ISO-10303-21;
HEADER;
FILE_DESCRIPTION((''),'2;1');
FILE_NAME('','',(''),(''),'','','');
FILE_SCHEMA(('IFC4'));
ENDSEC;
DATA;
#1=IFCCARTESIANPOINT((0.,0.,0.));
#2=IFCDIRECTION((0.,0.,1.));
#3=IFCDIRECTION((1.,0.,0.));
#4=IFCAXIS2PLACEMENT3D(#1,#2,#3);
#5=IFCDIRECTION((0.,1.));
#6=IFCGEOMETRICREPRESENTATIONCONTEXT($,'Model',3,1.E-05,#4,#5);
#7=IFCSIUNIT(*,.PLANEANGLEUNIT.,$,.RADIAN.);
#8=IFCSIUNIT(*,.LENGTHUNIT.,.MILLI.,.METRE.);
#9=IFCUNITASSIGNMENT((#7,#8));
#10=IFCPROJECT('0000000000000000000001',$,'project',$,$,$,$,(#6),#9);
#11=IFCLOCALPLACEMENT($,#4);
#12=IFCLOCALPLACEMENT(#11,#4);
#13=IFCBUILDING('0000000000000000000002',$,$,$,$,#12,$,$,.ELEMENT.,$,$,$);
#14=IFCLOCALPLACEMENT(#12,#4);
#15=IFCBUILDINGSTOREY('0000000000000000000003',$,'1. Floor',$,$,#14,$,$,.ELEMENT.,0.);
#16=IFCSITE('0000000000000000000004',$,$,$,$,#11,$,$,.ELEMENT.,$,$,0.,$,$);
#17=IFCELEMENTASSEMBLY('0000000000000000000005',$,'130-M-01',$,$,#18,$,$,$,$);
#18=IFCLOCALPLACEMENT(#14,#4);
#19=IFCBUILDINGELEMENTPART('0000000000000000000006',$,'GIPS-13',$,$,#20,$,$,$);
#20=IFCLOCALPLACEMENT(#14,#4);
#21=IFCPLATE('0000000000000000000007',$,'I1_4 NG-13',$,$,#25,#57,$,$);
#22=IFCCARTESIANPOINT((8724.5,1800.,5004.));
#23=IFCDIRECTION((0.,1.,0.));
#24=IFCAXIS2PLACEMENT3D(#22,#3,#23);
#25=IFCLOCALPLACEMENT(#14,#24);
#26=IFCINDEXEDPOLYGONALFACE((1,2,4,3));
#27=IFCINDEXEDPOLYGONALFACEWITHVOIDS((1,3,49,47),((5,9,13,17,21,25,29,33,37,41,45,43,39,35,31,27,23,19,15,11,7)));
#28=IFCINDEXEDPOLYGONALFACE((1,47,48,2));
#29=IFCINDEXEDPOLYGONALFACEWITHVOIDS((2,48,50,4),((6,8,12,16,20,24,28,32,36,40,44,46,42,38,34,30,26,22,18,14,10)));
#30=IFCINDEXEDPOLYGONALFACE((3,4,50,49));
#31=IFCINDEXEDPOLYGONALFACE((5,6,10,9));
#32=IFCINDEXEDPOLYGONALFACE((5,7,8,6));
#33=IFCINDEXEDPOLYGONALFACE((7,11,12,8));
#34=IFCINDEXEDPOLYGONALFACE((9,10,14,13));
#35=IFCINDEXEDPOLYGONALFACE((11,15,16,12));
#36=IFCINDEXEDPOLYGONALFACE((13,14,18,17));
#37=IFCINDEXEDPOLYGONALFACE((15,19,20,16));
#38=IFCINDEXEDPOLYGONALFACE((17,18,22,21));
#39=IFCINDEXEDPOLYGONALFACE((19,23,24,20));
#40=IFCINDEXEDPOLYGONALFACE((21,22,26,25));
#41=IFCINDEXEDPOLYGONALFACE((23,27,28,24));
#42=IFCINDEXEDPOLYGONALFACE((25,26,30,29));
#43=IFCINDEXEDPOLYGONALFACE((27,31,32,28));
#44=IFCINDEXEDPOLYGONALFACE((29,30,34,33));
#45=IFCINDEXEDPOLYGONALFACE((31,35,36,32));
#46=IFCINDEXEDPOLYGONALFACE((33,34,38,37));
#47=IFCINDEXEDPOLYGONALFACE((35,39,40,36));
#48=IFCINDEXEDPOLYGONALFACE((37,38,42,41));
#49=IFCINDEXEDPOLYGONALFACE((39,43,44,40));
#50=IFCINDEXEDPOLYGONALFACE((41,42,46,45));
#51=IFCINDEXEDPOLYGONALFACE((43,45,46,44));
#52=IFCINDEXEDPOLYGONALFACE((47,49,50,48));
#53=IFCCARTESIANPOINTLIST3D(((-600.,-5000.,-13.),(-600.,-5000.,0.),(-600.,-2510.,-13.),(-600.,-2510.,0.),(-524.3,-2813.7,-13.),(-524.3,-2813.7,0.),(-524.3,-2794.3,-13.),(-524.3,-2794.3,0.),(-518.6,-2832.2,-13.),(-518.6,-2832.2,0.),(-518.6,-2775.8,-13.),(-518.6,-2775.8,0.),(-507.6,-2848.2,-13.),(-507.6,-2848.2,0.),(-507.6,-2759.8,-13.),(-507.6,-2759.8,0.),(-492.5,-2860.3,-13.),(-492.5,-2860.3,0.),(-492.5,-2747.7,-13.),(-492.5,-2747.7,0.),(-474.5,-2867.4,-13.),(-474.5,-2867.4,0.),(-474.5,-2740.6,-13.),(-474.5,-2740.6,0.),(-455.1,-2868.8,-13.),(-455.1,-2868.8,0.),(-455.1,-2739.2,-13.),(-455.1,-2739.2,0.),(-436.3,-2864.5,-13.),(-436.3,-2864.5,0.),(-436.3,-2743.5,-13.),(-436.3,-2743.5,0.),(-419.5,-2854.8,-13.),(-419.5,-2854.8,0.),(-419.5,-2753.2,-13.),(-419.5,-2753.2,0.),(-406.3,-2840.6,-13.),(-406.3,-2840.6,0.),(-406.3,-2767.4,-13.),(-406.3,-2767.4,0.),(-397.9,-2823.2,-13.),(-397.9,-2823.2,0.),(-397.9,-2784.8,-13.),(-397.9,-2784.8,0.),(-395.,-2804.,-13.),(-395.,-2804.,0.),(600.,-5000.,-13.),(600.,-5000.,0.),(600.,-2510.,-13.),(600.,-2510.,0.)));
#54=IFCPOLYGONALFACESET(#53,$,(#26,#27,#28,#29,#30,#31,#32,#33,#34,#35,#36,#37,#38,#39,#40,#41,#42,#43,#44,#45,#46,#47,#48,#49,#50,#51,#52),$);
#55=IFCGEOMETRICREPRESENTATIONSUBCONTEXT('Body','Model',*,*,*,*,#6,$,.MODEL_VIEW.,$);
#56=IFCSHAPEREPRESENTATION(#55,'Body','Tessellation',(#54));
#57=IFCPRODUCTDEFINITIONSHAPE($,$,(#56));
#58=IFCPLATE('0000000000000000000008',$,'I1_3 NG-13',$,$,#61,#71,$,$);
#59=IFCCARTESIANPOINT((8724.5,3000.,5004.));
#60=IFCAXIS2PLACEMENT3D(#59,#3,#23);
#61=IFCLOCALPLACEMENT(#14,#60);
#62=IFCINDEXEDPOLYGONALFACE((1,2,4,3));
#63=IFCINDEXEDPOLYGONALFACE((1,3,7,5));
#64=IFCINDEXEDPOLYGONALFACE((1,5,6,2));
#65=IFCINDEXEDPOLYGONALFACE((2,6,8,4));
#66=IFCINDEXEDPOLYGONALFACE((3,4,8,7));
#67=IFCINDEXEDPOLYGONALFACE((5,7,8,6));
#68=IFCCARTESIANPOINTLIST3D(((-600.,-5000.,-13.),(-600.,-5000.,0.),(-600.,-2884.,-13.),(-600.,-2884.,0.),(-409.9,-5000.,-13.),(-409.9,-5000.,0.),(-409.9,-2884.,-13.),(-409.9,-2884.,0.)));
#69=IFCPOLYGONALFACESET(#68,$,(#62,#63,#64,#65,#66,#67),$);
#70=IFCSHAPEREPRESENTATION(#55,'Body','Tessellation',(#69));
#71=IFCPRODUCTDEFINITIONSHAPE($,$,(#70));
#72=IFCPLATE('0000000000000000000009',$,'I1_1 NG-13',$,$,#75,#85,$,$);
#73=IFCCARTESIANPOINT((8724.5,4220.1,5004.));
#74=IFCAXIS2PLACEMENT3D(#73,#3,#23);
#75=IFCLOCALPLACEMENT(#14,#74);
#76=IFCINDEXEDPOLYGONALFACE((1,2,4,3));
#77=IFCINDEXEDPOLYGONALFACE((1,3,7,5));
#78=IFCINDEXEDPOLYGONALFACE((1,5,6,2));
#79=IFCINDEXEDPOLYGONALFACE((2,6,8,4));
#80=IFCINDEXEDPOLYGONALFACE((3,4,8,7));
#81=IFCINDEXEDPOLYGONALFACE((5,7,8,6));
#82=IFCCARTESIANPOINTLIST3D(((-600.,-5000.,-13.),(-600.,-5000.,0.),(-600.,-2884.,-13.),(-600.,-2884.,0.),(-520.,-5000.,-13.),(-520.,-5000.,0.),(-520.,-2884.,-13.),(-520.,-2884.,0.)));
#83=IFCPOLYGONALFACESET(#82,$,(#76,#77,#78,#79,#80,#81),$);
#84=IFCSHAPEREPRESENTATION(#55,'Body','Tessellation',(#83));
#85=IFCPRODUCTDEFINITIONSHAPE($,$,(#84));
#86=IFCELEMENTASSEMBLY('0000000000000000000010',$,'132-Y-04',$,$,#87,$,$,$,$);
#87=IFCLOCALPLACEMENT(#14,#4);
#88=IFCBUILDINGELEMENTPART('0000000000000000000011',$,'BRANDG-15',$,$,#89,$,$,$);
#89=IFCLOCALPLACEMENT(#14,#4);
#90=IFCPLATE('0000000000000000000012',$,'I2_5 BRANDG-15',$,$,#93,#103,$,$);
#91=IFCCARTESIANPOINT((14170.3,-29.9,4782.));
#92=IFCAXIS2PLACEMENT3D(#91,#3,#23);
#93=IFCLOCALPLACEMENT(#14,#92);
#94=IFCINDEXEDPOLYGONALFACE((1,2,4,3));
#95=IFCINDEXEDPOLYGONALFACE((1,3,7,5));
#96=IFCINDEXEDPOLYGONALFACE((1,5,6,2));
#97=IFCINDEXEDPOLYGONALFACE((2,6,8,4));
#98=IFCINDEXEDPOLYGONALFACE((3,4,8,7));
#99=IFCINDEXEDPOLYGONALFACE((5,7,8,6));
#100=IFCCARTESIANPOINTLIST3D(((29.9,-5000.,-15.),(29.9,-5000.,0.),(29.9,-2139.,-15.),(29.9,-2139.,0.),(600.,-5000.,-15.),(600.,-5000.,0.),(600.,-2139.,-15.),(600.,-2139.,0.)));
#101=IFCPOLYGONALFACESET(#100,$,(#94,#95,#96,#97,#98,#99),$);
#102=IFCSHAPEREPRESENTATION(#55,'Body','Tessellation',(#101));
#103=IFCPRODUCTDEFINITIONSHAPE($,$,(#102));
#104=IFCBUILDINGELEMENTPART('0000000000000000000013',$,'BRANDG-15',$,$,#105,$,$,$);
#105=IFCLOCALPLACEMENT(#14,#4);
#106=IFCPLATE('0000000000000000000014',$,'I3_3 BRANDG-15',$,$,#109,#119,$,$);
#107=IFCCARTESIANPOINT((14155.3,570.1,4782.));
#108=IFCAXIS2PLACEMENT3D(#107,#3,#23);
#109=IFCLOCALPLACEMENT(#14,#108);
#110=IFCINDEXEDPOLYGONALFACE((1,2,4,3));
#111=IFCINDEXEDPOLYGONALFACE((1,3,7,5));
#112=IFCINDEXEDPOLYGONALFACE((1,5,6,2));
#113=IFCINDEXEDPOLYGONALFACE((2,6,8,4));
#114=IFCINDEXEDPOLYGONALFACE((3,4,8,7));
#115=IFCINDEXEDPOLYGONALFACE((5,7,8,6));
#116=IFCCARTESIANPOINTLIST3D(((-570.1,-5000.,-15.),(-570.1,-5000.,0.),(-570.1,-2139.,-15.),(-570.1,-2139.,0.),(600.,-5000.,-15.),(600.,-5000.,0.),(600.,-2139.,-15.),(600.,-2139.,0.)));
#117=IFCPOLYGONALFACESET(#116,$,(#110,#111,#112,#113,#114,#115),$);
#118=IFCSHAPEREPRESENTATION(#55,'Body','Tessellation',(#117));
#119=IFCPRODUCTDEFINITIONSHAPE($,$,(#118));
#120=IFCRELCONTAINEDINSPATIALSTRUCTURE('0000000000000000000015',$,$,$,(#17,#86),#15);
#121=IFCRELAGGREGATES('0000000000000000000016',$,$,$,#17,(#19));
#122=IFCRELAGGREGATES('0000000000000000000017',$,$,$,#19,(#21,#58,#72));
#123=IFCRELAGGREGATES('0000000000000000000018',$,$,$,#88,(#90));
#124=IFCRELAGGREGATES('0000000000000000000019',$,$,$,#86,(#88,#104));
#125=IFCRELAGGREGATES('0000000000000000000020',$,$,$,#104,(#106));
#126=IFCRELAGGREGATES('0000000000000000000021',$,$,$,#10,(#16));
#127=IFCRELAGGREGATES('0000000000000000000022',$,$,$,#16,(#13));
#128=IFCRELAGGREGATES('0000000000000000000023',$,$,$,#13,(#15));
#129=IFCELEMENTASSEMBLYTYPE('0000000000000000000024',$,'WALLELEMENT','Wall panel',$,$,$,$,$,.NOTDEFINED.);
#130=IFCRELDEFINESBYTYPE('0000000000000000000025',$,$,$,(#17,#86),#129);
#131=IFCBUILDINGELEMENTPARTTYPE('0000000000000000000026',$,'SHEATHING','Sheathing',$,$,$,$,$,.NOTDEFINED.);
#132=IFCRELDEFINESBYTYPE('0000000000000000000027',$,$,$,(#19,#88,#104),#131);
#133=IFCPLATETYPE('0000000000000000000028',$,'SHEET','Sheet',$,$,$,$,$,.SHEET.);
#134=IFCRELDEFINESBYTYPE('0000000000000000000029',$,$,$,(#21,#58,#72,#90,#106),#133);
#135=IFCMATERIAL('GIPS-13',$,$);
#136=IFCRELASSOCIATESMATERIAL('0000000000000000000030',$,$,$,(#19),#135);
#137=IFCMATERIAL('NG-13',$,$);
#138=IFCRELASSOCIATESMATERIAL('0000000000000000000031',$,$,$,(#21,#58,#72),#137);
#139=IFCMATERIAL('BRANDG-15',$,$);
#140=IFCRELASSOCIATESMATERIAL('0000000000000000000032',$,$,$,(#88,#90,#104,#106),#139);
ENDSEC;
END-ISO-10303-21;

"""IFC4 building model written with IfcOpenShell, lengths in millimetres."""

from ifc_helpers import new_model, si_unit, direction, frame, origin_with_axes, origin_2d_with_axis, place, context, subcontext, project, spatial, rectangle, circle, extrude, boolean, material, type_object, element, aggregate, save


model = new_model("IFC4")

# Units and contexts
model_context = context("Model", 3, precision=1e-05, world=origin_with_axes(), true_north=direction((0.0, 1.0)))
body_context = subcontext(model_context, "Body", "Model", "MODEL_VIEW")
ifc_project = project(units=[si_unit("PLANEANGLEUNIT", "RADIAN"), si_unit("LENGTHUNIT", "METRE", prefix="MILLI")], contexts=[model_context])

# Site, building, storey
site_placement = place(None, origin_with_axes())
site = spatial("IfcSite", under=ifc_project, at=site_placement, CompositionType="ELEMENT", RefElevation=0.0)
building_placement = place(site_placement, origin_with_axes())
building = spatial("IfcBuilding", under=site, at=building_placement, CompositionType="ELEMENT")
storey_placement = place(building_placement, origin_with_axes())
storey = spatial("IfcBuildingStorey", under=building, at=storey_placement, Name="1. Floor", CompositionType="ELEMENT", Elevation=0.0)

# Shared definitions
element_assembly_type = type_object("IfcElementAssemblyType", Name="WALLELEMENT", Description="Wall panel", PredefinedType="NOTDEFINED")
ifc_material_1 = material(Name="BRANDG-15")
building_element_part_type_1 = type_object("IfcBuildingElementPartType", Name="SHEATHING", Description="Sheathing", PredefinedType="NOTDEFINED")
plate_type = type_object("IfcPlateType", Name="SHEET", Description="Sheet", PredefinedType="SHEET")

# Element assemblies, building element parts, plates
assembly_1_placement = place(storey_placement, origin_with_axes())
assembly_1 = element("IfcElementAssembly", 1, at=assembly_1_placement, inside=storey, type_object=element_assembly_type, Name="130-M-01")
ifc_material_2 = material(Name="GIPS-13")
ifc_material_3 = material(Name="NG-13")
building_element_part_1_placement = place(storey_placement, origin_with_axes())
building_element_part_1 = element("IfcBuildingElementPart", 2, at=building_element_part_1_placement, type_object=building_element_part_type_1, material=ifc_material_2, Name="GIPS-13")
aggregate(assembly_1, [building_element_part_1])
plate_1_placement = place(storey_placement, frame((8724.5, 1800.0, 5004.0), z_axis=(1.0, 0.0, 0.0), x_axis=(0.0, 1.0, 0.0)))
plate_1 = element("IfcPlate", 3, at=plate_1_placement, type_object=plate_type, material=ifc_material_3, Name="I1_4 NG-13", context=body_context, shape_type="CSG", body=[
    boolean("DIFFERENCE", extrude(rectangle(XDim=13.0, YDim=1200.0, at=origin_2d_with_axis()), frame((0.0, -5000.0, -6.5), z_axis=(0.0, 1.0, 0.0), x_axis=(0.0, 0.0, 1.0)), (0.0, 0.0, 1.0), 2490.0), extrude(circle(Radius=65.0, at=origin_2d_with_axis()), frame((-460.0, -2804.0, -27.0), z_axis=(0.0, 0.0, -1.0), x_axis=(1.0, 0.0, 0.0)), (0.0, 0.0, -1.0), 63.0)),
])
plate_2_placement = place(storey_placement, frame((8724.5, 3000.0, 5004.0), z_axis=(1.0, 0.0, 0.0), x_axis=(0.0, 1.0, 0.0)))
plate_2 = element("IfcPlate", 4, at=plate_2_placement, type_object=plate_type, material=ifc_material_3, Name="I1_3 NG-13", context=body_context, shape_type="SweptSolid", body=[
    extrude(rectangle(XDim=13.0, YDim=190.1, at=origin_2d_with_axis()), frame((-504.9, -5000.0, -6.5), z_axis=(0.0, 1.0, 0.0), x_axis=(0.0, 0.0, 1.0)), (0.0, 0.0, 1.0), 2116.0),
])
plate_3_placement = place(storey_placement, frame((8724.5, 4220.1, 5004.0), z_axis=(1.0, 0.0, 0.0), x_axis=(0.0, 1.0, 0.0)))
plate_3 = element("IfcPlate", 5, at=plate_3_placement, type_object=plate_type, material=ifc_material_3, Name="I1_1 NG-13", context=body_context, shape_type="SweptSolid", body=[
    extrude(rectangle(XDim=13.0, YDim=80.0, at=origin_2d_with_axis()), frame((-560.0, -5000.0, -6.5), z_axis=(0.0, 1.0, 0.0), x_axis=(0.0, 0.0, 1.0)), (0.0, 0.0, 1.0), 2116.0),
])
aggregate(building_element_part_1, [plate_1, plate_2, plate_3])
assembly_2_placement = place(storey_placement, origin_with_axes())
assembly_2 = element("IfcElementAssembly", 6, at=assembly_2_placement, inside=storey, type_object=element_assembly_type, Name="132-Y-04")
building_element_part_2_placement = place(storey_placement, origin_with_axes())
building_element_part_2 = element("IfcBuildingElementPart", 7, at=building_element_part_2_placement, type_object=building_element_part_type_1, material=ifc_material_1, Name="BRANDG-15")
plate_4_placement = place(storey_placement, frame((14170.3, -29.9, 4782.0), z_axis=(1.0, 0.0, 0.0), x_axis=(0.0, 1.0, 0.0)))
plate_4 = element("IfcPlate", 8, at=plate_4_placement, type_object=plate_type, material=ifc_material_1, Name="I2_5 BRANDG-15", context=body_context, shape_type="SweptSolid", body=[
    extrude(rectangle(XDim=15.0, YDim=570.1, at=origin_2d_with_axis()), frame((314.9, -5000.0, -7.5), z_axis=(0.0, 1.0, 0.0), x_axis=(0.0, 0.0, 1.0)), (0.0, 0.0, 1.0), 2861.0),
])
aggregate(building_element_part_2, [plate_4])
building_element_part_3_placement = place(storey_placement, origin_with_axes())
building_element_part_3 = element("IfcBuildingElementPart", 9, at=building_element_part_3_placement, type_object=building_element_part_type_1, material=ifc_material_1, Name="BRANDG-15")
aggregate(assembly_2, [building_element_part_2, building_element_part_3])
plate_5_placement = place(storey_placement, frame((14155.3, 570.1, 4782.0), z_axis=(1.0, 0.0, 0.0), x_axis=(0.0, 1.0, 0.0)))
plate_5 = element("IfcPlate", 10, at=plate_5_placement, type_object=plate_type, material=ifc_material_1, Name="I3_3 BRANDG-15", context=body_context, shape_type="SweptSolid", body=[
    extrude(rectangle(XDim=15.0, YDim=1170.1, at=origin_2d_with_axis()), frame((14.9, -5000.0, -7.5), z_axis=(0.0, 1.0, 0.0), x_axis=(0.0, 0.0, 1.0)), (0.0, 0.0, 1.0), 2861.0),
])
aggregate(building_element_part_3, [plate_5])

save(model, "model.ifc")
